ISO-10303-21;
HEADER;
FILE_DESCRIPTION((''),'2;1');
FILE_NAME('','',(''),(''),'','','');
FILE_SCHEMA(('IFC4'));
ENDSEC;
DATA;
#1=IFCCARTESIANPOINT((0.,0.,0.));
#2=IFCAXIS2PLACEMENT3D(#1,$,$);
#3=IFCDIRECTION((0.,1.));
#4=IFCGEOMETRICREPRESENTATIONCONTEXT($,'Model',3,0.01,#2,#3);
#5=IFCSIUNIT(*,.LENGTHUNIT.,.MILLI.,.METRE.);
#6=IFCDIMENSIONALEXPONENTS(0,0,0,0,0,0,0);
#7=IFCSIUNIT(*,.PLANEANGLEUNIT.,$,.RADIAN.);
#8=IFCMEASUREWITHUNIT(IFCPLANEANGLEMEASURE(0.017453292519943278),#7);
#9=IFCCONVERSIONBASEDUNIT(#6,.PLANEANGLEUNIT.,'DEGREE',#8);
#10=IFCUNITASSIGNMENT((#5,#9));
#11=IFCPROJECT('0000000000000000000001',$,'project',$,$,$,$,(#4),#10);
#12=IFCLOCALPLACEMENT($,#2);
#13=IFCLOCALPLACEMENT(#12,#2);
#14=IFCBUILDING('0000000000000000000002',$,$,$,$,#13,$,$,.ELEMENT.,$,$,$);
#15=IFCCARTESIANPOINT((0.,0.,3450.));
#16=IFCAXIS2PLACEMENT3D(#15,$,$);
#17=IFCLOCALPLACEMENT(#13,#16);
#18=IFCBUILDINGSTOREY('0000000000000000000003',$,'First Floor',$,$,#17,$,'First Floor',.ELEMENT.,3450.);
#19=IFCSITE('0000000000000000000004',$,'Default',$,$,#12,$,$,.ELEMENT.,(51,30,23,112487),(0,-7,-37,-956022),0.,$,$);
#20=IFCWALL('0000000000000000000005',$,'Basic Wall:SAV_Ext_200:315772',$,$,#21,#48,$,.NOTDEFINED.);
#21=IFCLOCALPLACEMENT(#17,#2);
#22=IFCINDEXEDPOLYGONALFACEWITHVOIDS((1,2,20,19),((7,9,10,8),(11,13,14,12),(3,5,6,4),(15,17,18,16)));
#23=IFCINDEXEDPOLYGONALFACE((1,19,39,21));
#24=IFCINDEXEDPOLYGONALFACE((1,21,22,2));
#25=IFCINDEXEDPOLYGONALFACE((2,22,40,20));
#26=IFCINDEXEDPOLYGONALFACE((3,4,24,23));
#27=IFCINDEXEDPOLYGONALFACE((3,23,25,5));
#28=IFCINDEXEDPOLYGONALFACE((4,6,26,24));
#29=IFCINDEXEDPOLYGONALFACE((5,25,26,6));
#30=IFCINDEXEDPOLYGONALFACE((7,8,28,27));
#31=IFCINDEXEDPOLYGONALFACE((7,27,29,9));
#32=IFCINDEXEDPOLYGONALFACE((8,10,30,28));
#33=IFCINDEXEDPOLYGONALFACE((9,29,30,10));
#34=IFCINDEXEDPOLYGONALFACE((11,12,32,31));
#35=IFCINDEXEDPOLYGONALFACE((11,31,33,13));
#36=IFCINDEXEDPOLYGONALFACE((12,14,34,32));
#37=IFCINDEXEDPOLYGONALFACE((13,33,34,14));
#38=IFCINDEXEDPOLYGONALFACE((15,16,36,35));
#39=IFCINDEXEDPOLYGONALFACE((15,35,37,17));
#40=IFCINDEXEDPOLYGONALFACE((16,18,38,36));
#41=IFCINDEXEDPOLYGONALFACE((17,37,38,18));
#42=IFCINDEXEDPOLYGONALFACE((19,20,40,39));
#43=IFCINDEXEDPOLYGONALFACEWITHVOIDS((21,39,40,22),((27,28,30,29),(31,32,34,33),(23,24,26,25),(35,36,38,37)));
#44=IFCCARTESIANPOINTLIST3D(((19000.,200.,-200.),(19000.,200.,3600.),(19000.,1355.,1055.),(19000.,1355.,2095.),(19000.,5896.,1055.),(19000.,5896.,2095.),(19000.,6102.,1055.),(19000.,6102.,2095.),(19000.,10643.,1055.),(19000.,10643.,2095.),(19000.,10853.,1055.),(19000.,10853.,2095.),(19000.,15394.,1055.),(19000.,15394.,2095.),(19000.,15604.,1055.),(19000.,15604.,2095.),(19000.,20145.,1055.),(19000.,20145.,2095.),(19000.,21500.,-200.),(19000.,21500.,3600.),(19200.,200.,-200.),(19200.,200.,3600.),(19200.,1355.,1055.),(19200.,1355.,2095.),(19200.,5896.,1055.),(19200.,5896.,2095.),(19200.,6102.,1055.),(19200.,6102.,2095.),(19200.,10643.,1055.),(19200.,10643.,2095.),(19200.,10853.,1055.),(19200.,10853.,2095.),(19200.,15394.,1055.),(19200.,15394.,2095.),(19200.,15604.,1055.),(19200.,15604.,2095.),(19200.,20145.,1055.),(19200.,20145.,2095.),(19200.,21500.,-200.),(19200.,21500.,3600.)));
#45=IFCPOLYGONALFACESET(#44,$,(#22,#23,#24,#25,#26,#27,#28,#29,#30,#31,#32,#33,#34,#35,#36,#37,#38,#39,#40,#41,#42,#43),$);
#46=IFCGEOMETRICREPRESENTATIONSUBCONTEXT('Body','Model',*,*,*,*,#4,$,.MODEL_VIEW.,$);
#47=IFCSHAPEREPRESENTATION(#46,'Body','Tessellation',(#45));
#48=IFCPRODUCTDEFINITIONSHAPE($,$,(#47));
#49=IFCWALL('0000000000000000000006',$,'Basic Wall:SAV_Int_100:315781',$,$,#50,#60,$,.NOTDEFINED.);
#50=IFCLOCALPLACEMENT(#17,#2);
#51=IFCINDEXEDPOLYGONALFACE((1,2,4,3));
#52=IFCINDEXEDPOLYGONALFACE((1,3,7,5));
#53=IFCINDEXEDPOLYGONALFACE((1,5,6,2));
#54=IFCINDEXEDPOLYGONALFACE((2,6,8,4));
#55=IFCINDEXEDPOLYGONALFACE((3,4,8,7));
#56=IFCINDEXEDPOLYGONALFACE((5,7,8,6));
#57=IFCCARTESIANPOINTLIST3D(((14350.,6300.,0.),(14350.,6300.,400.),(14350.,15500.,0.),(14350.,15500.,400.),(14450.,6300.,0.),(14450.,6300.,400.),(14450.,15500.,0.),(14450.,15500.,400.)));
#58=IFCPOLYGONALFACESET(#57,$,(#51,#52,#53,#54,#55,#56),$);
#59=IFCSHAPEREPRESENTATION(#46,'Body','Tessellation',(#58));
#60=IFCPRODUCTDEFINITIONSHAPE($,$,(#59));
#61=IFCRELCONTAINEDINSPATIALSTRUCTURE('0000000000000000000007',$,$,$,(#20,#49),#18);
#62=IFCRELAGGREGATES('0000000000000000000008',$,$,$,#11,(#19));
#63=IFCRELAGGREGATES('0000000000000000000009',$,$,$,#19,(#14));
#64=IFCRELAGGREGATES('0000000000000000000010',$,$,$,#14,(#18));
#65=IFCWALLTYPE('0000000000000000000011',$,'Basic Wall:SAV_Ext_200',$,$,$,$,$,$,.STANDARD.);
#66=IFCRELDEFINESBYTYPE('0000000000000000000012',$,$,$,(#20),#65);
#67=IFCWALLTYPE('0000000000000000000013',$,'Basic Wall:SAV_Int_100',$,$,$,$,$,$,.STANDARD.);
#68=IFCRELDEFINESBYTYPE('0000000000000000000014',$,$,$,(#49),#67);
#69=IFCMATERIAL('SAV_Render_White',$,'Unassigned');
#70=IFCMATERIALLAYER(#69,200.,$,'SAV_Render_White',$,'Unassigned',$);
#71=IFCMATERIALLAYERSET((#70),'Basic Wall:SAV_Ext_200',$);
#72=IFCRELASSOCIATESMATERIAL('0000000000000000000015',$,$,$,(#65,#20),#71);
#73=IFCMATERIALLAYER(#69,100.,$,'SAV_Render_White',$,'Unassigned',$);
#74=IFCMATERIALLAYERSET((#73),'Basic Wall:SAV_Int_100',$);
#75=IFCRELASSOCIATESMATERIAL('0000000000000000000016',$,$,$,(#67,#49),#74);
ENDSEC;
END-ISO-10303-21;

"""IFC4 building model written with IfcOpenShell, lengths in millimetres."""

from ifc_helpers import new_model, entity, si_unit, converted_unit, direction, frame, frame_2d, origin, place, context, subcontext, project, spatial, rectangle, extrude, material, layer, layer_set, layer_usage, type_object, element, save


model = new_model("IFC4")

# Units and contexts
model_context = context("Model", 3, precision=0.01, world=origin(), true_north=direction((0.0, 1.0)))
body_context = subcontext(model_context, "Body", "Model", "MODEL_VIEW")
ifc_project = project(units=[si_unit("LENGTHUNIT", "METRE", prefix="MILLI"), converted_unit("PLANEANGLEUNIT", "DEGREE", entity("IfcPlaneAngleMeasure", 0.017453292519943278), si_unit("PLANEANGLEUNIT", "RADIAN"), dimensions=[0, 0, 0, 0, 0, 0, 0])], contexts=[model_context])

# Site, building, storey
site_placement = place(None, origin())
site = spatial("IfcSite", under=ifc_project, at=site_placement, Name="Default", CompositionType="ELEMENT", RefLatitude=(51, 30, 23, 112487), RefLongitude=(0, -7, -37, -956022), RefElevation=0.0)
building_placement = place(site_placement, origin())
building = spatial("IfcBuilding", under=site, at=building_placement, CompositionType="ELEMENT")
storey_placement = place(building_placement, frame((0.0, 0.0, 3450.0)))
storey = spatial("IfcBuildingStorey", under=building, at=storey_placement, Name="First Floor", LongName="First Floor", CompositionType="ELEMENT", Elevation=3450.0)

# Wall, openings
ifc_material_1 = material(Name="SAV_Render_White", Category="Unassigned")
ifc_layer_1 = layer(ifc_material_1, 200.0, Name="SAV_Render_White", Category="Unassigned")
ifc_layer_set_1 = layer_set([ifc_layer_1], Name="Basic Wall:SAV_Ext_200")
ifc_layer_usage_1 = layer_usage(ifc_layer_set_1, "AXIS2", "NEGATIVE", 100.0)
wall_type_1 = type_object("IfcWallType", Name="Basic Wall:SAV_Ext_200", PredefinedType="STANDARD", material=ifc_layer_set_1)
wall_1_placement = place(storey_placement, frame((19100.0, 200.0, -200.0), z_axis=(0.0, 0.0, 1.0), x_axis=(0.0, 1.0, 0.0)))
wall_1 = element("IfcWall", 1, at=wall_1_placement, inside=storey, type_object=wall_type_1, material=ifc_layer_usage_1, Name="Basic Wall:SAV_Ext_200:315772", PredefinedType="NOTDEFINED", context=body_context, shape_type="SweptSolid", body=[
    extrude(rectangle(XDim=21300.0, YDim=200.0, at=frame_2d((10650.0, 0.0), x_axis=(-1.0, 0.0))), origin(), (0.0, 0.0, 1.0), 3800.0),
])
opening_1_placement = place(wall_1_placement, frame((5902.0, 100.0, 1255.0)))
element("IfcOpeningElement", 2, at=opening_1_placement, cuts=wall_1, PredefinedType="OPENING", context=body_context, shape_type="SweptSolid", body=[
    extrude(rectangle(XDim=1040.0, YDim=4541.0, at=frame_2d((0.0, 0.0), x_axis=(1.0, 0.0))), frame((2270.5, -200.0, 520.0), z_axis=(0.0, 1.0, 0.0), x_axis=(0.0, 0.0, -1.0)), (0.0, 0.0, 1.0), 200.0),
])
opening_2_placement = place(wall_1_placement, frame((10653.0, 100.0, 1255.0)))
element("IfcOpeningElement", 3, at=opening_2_placement, cuts=wall_1, PredefinedType="OPENING", context=body_context, shape_type="SweptSolid", body=[
    extrude(rectangle(XDim=1040.0, YDim=4541.0, at=frame_2d((0.0, 0.0), x_axis=(1.0, 0.0))), frame((2270.5, -200.0, 520.0), z_axis=(0.0, 1.0, 0.0), x_axis=(0.0, 0.0, -1.0)), (0.0, 0.0, 1.0), 200.0),
])
opening_3_placement = place(wall_1_placement, frame((1155.0, -100.0, 1255.0)))
element("IfcOpeningElement", 4, at=opening_3_placement, cuts=wall_1, PredefinedType="OPENING", context=body_context, shape_type="SweptSolid", body=[
    extrude(rectangle(XDim=1040.0, YDim=4541.0, at=frame_2d((520.0, 2270.5), x_axis=(-1.0, 0.0))), frame((0.0, 0.0, 0.0), z_axis=(0.0, 1.0, 0.0), x_axis=(0.0, 0.0, 1.0)), (0.0, 0.0, 1.0), 200.0),
])
opening_4_placement = place(wall_1_placement, frame((15404.0, -100.0, 1255.0)))
element("IfcOpeningElement", 5, at=opening_4_placement, cuts=wall_1, PredefinedType="OPENING", context=body_context, shape_type="SweptSolid", body=[
    extrude(rectangle(XDim=1040.0, YDim=4541.0, at=frame_2d((520.0, 2270.5), x_axis=(-1.0, 0.0))), frame((0.0, 0.0, 0.0), z_axis=(0.0, 1.0, 0.0), x_axis=(0.0, 0.0, 1.0)), (0.0, 0.0, 1.0), 200.0),
])

# Wall
ifc_layer_2 = layer(ifc_material_1, 100.0, Name="SAV_Render_White", Category="Unassigned")
ifc_layer_set_2 = layer_set([ifc_layer_2], Name="Basic Wall:SAV_Int_100")
ifc_layer_usage_2 = layer_usage(ifc_layer_set_2, "AXIS2", "NEGATIVE", 50.0)
wall_type_2 = type_object("IfcWallType", Name="Basic Wall:SAV_Int_100", PredefinedType="STANDARD", material=ifc_layer_set_2)
wall_2_placement = place(storey_placement, frame((14400.0, 6300.0, 0.0), z_axis=(0.0, 0.0, 1.0), x_axis=(0.0, 1.0, 0.0)))
element("IfcWall", 6, at=wall_2_placement, inside=storey, type_object=wall_type_2, material=ifc_layer_usage_2, Name="Basic Wall:SAV_Int_100:315781", PredefinedType="NOTDEFINED", context=body_context, shape_type="SweptSolid", body=[
    extrude(rectangle(XDim=9200.0, YDim=100.0, at=frame_2d((4600.0, 0.0), x_axis=(-1.0, 0.0))), origin(), (0.0, 0.0, 1.0), 400.0),
])

save(model, "model.ifc")
